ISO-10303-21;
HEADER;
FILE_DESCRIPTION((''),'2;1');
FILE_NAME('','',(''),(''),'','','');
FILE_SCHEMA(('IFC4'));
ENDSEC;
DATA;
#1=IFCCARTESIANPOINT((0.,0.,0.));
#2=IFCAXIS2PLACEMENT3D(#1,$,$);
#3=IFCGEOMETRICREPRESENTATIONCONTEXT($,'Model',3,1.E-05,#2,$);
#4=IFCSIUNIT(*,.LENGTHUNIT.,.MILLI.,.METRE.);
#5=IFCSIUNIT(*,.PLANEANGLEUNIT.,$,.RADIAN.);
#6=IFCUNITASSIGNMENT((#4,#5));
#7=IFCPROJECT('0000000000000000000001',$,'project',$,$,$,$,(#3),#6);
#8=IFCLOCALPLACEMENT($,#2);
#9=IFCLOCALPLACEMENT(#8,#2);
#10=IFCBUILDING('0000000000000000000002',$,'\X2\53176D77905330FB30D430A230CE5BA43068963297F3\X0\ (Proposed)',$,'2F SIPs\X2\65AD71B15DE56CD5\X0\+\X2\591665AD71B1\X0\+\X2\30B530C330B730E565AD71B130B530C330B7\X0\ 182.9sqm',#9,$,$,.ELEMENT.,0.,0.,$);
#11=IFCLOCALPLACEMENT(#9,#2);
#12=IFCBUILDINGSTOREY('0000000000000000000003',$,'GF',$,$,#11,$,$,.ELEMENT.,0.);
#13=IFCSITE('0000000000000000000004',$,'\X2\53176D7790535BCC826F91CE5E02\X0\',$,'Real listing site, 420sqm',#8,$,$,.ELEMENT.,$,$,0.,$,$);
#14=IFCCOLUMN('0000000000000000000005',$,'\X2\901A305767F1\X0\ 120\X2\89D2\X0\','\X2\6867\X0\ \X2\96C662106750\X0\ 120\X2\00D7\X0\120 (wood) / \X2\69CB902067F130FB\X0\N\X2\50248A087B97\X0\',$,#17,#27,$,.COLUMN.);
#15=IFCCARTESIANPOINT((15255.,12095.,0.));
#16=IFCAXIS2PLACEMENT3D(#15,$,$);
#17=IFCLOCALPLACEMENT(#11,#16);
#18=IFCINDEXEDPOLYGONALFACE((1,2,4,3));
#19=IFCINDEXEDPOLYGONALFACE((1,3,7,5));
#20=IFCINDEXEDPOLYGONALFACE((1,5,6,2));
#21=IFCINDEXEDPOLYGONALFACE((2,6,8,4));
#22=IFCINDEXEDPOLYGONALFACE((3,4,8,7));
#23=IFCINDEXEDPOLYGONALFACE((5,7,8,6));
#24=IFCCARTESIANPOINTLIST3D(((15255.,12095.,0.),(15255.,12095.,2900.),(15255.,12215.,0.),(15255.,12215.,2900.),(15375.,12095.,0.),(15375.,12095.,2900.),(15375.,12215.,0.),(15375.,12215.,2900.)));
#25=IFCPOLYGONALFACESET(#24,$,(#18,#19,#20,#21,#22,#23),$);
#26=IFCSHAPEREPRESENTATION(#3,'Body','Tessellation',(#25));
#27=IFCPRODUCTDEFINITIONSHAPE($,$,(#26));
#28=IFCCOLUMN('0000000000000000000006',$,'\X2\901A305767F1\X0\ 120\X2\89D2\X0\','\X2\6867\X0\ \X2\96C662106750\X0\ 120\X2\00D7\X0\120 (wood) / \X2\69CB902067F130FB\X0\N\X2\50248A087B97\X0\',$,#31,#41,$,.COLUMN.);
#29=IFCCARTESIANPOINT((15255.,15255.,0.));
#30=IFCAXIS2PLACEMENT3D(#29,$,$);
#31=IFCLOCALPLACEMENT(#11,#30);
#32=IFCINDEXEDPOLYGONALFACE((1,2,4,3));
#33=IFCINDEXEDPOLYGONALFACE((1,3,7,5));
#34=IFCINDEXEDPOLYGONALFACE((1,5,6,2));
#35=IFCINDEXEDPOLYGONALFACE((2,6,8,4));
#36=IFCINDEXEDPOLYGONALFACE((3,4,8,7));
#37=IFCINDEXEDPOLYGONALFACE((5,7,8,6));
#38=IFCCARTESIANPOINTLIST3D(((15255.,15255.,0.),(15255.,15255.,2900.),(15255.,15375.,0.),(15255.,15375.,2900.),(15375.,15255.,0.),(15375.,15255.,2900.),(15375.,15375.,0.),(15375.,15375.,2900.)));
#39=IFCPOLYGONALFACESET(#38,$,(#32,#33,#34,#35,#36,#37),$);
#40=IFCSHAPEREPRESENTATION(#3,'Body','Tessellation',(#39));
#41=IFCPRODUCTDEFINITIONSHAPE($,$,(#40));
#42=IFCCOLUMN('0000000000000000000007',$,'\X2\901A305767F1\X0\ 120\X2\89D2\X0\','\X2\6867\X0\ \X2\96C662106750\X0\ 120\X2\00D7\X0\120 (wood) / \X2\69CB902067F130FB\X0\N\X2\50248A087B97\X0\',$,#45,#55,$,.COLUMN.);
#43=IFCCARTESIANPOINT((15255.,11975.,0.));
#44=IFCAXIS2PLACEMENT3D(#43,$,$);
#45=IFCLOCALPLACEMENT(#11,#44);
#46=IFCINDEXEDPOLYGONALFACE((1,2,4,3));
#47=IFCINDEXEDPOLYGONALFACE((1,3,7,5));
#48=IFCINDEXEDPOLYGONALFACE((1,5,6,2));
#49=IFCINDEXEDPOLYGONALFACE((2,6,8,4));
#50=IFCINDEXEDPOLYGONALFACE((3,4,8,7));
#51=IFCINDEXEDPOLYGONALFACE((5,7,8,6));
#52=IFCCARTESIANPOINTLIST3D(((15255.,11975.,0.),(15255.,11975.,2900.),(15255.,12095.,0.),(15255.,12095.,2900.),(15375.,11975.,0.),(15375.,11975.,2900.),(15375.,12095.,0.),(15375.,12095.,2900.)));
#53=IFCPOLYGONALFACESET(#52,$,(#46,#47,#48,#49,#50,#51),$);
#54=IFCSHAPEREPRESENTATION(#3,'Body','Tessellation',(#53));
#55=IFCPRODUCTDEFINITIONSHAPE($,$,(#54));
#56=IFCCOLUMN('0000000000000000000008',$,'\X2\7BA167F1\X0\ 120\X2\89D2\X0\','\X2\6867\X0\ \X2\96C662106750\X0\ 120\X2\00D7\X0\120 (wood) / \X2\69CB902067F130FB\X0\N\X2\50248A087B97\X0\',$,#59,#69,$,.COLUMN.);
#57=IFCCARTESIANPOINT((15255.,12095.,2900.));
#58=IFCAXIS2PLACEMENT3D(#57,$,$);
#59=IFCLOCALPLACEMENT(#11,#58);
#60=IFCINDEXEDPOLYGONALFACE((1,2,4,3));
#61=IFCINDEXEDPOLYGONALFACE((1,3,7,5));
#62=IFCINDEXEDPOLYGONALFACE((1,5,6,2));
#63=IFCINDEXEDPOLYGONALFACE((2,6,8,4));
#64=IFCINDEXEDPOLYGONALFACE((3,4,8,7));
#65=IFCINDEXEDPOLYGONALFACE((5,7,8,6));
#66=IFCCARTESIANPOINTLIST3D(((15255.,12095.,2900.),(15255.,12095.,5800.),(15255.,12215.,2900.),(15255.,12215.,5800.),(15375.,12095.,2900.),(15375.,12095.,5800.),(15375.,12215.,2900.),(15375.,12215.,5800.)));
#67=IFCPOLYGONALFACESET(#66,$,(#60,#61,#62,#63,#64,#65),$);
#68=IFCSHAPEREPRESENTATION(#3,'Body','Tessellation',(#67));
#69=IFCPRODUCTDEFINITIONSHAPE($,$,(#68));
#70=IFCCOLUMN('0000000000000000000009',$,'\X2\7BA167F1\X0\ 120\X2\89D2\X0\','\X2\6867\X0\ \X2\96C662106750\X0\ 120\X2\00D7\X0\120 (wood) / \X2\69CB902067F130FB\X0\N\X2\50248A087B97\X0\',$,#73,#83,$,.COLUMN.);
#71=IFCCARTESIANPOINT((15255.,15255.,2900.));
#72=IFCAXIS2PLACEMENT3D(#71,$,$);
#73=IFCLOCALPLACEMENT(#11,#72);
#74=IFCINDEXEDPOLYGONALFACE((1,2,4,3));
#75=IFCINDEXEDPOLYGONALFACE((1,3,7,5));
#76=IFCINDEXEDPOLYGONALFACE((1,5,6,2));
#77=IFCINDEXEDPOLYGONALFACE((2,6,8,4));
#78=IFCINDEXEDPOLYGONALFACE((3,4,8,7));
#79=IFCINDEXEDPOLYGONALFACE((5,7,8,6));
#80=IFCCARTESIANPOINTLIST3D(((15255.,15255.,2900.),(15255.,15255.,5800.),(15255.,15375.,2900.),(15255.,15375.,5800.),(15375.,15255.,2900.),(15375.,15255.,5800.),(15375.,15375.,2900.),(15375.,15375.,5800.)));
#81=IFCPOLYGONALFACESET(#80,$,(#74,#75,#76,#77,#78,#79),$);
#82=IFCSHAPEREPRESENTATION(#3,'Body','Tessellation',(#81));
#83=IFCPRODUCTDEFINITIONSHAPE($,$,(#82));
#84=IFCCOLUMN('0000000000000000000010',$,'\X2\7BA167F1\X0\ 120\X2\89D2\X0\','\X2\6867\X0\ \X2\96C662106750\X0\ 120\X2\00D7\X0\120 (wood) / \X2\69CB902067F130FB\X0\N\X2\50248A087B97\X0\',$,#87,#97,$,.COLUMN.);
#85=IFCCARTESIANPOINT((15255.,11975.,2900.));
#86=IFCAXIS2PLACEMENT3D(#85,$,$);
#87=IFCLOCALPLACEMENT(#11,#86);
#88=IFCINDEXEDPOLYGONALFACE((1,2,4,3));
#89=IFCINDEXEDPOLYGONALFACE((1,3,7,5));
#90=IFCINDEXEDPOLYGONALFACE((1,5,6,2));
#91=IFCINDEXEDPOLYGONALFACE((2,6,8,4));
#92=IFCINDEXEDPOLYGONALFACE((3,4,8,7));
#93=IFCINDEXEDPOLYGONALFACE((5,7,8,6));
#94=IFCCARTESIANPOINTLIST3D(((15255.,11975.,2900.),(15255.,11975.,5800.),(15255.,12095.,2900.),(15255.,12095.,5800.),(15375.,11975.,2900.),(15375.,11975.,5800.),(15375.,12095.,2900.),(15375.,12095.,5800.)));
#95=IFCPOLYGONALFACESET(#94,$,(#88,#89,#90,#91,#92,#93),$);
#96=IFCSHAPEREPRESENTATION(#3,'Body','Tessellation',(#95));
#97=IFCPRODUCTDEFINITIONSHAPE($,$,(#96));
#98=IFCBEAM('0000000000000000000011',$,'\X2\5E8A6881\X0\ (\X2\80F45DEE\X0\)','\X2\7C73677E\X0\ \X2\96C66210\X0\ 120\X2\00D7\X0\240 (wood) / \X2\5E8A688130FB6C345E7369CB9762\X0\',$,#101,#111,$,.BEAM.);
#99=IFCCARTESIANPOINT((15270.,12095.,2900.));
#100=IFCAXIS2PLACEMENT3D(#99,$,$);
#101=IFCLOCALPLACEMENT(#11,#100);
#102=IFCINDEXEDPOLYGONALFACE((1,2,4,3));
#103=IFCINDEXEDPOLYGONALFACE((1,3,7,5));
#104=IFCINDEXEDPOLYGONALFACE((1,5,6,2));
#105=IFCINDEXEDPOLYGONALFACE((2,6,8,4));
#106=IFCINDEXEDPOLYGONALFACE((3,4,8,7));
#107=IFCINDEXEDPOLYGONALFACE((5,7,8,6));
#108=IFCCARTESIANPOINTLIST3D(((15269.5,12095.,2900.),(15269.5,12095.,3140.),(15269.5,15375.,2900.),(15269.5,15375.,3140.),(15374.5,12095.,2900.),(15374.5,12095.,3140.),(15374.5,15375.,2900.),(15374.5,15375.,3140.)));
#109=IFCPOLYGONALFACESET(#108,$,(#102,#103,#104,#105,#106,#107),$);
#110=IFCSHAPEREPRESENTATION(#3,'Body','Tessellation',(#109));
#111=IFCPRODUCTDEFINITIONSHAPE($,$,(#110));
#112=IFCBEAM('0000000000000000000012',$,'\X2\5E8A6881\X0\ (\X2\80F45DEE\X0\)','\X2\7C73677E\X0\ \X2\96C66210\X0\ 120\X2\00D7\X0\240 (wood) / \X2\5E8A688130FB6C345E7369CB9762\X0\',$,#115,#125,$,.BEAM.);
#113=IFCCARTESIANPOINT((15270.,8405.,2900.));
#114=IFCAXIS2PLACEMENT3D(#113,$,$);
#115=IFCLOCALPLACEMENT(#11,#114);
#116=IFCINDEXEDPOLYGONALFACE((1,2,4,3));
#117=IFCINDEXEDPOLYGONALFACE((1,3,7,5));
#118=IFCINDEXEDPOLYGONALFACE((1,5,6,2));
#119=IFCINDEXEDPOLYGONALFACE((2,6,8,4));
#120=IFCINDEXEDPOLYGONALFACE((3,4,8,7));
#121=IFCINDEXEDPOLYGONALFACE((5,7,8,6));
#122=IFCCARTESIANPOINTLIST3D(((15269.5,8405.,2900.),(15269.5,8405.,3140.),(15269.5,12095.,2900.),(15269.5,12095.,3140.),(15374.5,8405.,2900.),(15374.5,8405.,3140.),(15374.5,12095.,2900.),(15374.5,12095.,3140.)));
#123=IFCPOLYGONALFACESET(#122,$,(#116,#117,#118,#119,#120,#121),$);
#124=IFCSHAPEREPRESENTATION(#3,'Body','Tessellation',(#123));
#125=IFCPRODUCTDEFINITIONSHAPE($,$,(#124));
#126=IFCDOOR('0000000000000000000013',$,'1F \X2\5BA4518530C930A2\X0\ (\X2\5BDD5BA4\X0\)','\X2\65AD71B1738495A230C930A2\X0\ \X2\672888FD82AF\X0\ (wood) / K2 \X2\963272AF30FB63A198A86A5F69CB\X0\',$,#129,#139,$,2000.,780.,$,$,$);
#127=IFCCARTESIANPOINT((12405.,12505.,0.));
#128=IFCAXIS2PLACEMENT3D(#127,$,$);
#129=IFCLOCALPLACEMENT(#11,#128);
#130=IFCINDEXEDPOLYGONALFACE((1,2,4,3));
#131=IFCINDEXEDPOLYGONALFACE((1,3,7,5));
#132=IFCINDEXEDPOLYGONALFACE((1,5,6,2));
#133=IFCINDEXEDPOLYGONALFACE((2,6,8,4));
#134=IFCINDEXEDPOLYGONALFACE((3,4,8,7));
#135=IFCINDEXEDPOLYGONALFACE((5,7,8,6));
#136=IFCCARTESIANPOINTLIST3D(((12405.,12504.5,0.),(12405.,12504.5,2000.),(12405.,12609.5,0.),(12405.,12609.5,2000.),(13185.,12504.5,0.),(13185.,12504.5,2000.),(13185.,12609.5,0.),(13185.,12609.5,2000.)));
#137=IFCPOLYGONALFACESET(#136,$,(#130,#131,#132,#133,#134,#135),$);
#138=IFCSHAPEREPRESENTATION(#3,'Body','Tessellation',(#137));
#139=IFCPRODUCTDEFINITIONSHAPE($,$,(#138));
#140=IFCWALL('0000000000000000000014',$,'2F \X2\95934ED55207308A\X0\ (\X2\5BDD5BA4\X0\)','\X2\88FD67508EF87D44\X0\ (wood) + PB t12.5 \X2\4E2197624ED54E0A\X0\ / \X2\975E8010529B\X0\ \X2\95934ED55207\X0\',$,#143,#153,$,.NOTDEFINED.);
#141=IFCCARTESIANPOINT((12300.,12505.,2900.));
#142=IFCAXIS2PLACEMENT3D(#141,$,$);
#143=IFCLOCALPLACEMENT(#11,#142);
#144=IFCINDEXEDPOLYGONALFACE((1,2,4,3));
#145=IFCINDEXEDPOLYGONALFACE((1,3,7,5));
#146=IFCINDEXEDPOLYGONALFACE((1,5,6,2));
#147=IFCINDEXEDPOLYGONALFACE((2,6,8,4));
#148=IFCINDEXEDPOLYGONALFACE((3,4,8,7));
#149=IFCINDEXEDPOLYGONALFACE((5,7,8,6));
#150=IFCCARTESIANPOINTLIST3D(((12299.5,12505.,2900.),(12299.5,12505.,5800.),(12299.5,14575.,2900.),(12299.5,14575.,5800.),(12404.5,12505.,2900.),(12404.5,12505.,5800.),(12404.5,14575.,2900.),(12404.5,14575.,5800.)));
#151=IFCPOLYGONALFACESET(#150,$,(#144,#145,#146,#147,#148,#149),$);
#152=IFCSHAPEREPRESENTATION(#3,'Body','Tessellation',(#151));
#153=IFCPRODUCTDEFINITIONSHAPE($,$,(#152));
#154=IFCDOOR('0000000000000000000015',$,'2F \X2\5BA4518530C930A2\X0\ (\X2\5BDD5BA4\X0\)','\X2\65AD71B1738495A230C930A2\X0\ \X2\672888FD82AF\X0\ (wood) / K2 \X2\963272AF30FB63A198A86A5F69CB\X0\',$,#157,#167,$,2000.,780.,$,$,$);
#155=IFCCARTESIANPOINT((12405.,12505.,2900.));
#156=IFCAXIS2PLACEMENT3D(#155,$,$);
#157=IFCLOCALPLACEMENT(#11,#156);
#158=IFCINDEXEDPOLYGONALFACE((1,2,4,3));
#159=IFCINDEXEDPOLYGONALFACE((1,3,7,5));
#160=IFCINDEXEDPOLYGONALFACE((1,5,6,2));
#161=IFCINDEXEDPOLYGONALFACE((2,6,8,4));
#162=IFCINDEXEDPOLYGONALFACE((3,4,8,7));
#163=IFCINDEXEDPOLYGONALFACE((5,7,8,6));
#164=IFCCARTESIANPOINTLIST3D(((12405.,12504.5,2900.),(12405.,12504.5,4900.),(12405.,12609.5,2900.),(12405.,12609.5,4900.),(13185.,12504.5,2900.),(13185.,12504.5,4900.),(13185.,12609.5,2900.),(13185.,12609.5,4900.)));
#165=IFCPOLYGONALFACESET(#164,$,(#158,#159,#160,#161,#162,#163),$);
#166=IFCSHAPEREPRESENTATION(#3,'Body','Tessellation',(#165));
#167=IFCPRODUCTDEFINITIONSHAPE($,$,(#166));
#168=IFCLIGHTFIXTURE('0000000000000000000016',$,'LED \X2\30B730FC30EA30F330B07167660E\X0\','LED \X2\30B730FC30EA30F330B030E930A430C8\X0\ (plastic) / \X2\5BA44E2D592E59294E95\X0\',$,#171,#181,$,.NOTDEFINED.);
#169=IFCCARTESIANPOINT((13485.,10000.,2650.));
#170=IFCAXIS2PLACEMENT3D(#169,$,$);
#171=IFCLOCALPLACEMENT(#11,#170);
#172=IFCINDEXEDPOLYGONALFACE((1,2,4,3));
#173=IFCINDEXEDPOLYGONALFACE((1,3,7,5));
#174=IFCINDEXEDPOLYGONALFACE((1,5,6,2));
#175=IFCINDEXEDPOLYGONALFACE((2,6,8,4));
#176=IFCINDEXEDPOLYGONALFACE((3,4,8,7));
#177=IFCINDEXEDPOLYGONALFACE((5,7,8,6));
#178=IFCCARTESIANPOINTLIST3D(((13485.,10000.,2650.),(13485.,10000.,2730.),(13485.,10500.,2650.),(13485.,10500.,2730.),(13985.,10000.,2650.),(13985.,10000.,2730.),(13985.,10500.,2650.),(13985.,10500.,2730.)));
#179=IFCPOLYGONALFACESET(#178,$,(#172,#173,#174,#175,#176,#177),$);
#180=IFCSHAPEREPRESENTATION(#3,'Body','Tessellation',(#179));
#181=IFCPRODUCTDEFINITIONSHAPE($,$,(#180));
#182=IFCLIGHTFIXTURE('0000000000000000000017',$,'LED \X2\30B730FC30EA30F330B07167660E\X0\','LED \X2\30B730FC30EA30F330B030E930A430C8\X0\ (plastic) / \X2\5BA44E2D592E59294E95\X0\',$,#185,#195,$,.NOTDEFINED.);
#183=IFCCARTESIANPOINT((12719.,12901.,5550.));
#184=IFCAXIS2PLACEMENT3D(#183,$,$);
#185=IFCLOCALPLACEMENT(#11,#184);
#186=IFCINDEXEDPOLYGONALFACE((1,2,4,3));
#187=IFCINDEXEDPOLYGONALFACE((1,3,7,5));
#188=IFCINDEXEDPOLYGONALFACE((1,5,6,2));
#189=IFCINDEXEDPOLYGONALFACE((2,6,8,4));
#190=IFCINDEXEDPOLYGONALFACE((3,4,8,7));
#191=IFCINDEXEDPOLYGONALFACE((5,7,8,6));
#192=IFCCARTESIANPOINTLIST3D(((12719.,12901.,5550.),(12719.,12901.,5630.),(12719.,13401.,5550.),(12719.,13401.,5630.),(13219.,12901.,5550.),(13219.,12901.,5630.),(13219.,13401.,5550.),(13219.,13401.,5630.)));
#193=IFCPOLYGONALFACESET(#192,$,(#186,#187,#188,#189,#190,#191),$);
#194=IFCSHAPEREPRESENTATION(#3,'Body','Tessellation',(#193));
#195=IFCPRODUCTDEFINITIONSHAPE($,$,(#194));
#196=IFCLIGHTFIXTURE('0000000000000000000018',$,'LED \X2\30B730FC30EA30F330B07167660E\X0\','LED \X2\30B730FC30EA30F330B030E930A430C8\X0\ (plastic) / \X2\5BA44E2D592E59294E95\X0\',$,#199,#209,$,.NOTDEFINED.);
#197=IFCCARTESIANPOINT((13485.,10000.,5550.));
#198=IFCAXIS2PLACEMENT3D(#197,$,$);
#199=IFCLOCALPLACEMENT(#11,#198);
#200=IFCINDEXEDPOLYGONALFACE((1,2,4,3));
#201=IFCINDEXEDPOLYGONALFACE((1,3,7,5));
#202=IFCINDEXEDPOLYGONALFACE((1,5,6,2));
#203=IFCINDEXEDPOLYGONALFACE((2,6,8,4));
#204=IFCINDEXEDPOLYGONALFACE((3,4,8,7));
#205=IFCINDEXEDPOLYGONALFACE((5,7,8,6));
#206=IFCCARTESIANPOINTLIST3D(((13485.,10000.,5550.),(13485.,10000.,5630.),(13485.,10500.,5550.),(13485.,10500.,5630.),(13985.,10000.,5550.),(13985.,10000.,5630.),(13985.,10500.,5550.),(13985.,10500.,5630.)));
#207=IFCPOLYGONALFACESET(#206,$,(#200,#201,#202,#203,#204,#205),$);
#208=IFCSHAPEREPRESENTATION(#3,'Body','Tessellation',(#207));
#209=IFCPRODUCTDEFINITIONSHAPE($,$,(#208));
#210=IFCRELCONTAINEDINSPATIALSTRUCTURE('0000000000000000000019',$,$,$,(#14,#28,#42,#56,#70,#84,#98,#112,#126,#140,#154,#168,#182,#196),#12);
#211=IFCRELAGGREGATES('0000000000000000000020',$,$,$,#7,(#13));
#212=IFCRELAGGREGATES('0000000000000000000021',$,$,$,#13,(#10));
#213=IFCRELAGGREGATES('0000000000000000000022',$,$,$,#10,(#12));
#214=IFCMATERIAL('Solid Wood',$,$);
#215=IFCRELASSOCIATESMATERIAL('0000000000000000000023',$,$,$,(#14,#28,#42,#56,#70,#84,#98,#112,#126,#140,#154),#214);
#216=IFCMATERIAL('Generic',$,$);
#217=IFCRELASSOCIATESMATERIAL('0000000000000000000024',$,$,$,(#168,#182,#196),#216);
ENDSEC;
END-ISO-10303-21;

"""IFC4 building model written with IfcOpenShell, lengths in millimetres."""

from ifc_helpers import new_model, si_unit, frame, frame_2d, origin, place, context, project, spatial, rectangle, extrude, material, element, save


model = new_model("IFC4")

# Units and contexts
model_context = context("Model", 3, precision=1e-05, world=origin())
ifc_project = project(units=[si_unit("LENGTHUNIT", "METRE", prefix="MILLI"), si_unit("PLANEANGLEUNIT", "RADIAN")], contexts=[model_context])

# Site, building, storey
site_placement = place(None, origin())
site = spatial("IfcSite", under=ifc_project, at=site_placement, Name="北海道富良野市", ObjectType="Real listing site, 420sqm", CompositionType="ELEMENT", RefElevation=0.0)
building_placement = place(site_placement, origin())
building = spatial("IfcBuilding", under=site, at=building_placement, Name="北海道・ピアノ室と防音 (Proposed)", ObjectType="2F SIPs断熱工法+外断熱+サッシュ断熱サッシ 182.9sqm", CompositionType="ELEMENT", ElevationOfRefHeight=0.0, ElevationOfTerrain=0.0)
storey_placement = place(building_placement, origin())
storey = spatial("IfcBuildingStorey", under=building, at=storey_placement, Name="GF", CompositionType="ELEMENT", Elevation=0.0)

# Columns
ifc_material_1 = material(Name="Solid Wood")
column_1_placement = place(storey_placement, frame((15255.0, 12095.0, 0.0)))
element("IfcColumn", 1, at=column_1_placement, inside=storey, material=ifc_material_1, Name="通し柱 120角", Description="桧 集成材 120×120 (wood) / 構造柱・N値計算", PredefinedType="COLUMN", context=model_context, shape_type="SweptSolid", body=[
    extrude(rectangle(XDim=120.0, YDim=120.0, at=frame_2d((60.0, 60.0))), frame((15255.0, 12095.0, 0.0)), (0.0, 0.0, 1.0), 2900.0),
])
column_2_placement = place(storey_placement, frame((15255.0, 15255.0, 0.0)))
element("IfcColumn", 2, at=column_2_placement, inside=storey, material=ifc_material_1, Name="通し柱 120角", Description="桧 集成材 120×120 (wood) / 構造柱・N値計算", PredefinedType="COLUMN", context=model_context, shape_type="SweptSolid", body=[
    extrude(rectangle(XDim=120.0, YDim=120.0, at=frame_2d((60.0, 60.0))), frame((15255.0, 15255.0, 0.0)), (0.0, 0.0, 1.0), 2900.0),
])
column_3_placement = place(storey_placement, frame((15255.0, 11975.0, 0.0)))
element("IfcColumn", 3, at=column_3_placement, inside=storey, material=ifc_material_1, Name="通し柱 120角", Description="桧 集成材 120×120 (wood) / 構造柱・N値計算", PredefinedType="COLUMN", context=model_context, shape_type="SweptSolid", body=[
    extrude(rectangle(XDim=120.0, YDim=120.0, at=frame_2d((60.0, 60.0))), frame((15255.0, 11975.0, 0.0)), (0.0, 0.0, 1.0), 2900.0),
])
column_4_placement = place(storey_placement, frame((15255.0, 12095.0, 2900.0)))
element("IfcColumn", 4, at=column_4_placement, inside=storey, material=ifc_material_1, Name="管柱 120角", Description="桧 集成材 120×120 (wood) / 構造柱・N値計算", PredefinedType="COLUMN", context=model_context, shape_type="SweptSolid", body=[
    extrude(rectangle(XDim=120.0, YDim=120.0, at=frame_2d((60.0, 60.0))), frame((15255.0, 12095.0, 2900.0)), (0.0, 0.0, 1.0), 2900.0),
])
column_5_placement = place(storey_placement, frame((15255.0, 15255.0, 2900.0)))
element("IfcColumn", 5, at=column_5_placement, inside=storey, material=ifc_material_1, Name="管柱 120角", Description="桧 集成材 120×120 (wood) / 構造柱・N値計算", PredefinedType="COLUMN", context=model_context, shape_type="SweptSolid", body=[
    extrude(rectangle(XDim=120.0, YDim=120.0, at=frame_2d((60.0, 60.0))), frame((15255.0, 15255.0, 2900.0)), (0.0, 0.0, 1.0), 2900.0),
])
column_6_placement = place(storey_placement, frame((15255.0, 11975.0, 2900.0)))
element("IfcColumn", 6, at=column_6_placement, inside=storey, material=ifc_material_1, Name="管柱 120角", Description="桧 集成材 120×120 (wood) / 構造柱・N値計算", PredefinedType="COLUMN", context=model_context, shape_type="SweptSolid", body=[
    extrude(rectangle(XDim=120.0, YDim=120.0, at=frame_2d((60.0, 60.0))), frame((15255.0, 11975.0, 2900.0)), (0.0, 0.0, 1.0), 2900.0),
])

# Beams
beam_1_placement = place(storey_placement, frame((15270.0, 12095.0, 2900.0)))
element("IfcBeam", 7, at=beam_1_placement, inside=storey, material=ifc_material_1, Name="床梁 (胴差)", Description="米松 集成 120×240 (wood) / 床梁・水平構面", PredefinedType="BEAM", context=model_context, shape_type="SweptSolid", body=[
    extrude(rectangle(XDim=105.0, YDim=3280.0, at=frame_2d((52.0, 1640.0))), frame((15270.0, 12095.0, 2900.0)), (0.0, 0.0, 1.0), 240.0),
])
beam_2_placement = place(storey_placement, frame((15270.0, 8405.0, 2900.0)))
element("IfcBeam", 8, at=beam_2_placement, inside=storey, material=ifc_material_1, Name="床梁 (胴差)", Description="米松 集成 120×240 (wood) / 床梁・水平構面", PredefinedType="BEAM", context=model_context, shape_type="SweptSolid", body=[
    extrude(rectangle(XDim=105.0, YDim=3690.0, at=frame_2d((52.0, 1845.0))), frame((15270.0, 8405.0, 2900.0)), (0.0, 0.0, 1.0), 240.0),
])

# Door
door_1_placement = place(storey_placement, frame((12405.0, 12505.0, 0.0)))
element("IfcDoor", 9, at=door_1_placement, inside=storey, material=ifc_material_1, Name="1F 室内ドア (寝室)", Description="断熱玄関ドア 木製芯 (wood) / K2 防犯・採風機構", OverallHeight=2000.0, OverallWidth=780.0, context=model_context, shape_type="SweptSolid", body=[
    extrude(rectangle(XDim=780.0, YDim=105.0, at=frame_2d((390.0, 52.0))), frame((12405.0, 12505.0, 0.0)), (0.0, 0.0, 1.0), 2000.0),
])

# Wall
wall_placement = place(storey_placement, frame((12300.0, 12505.0, 2900.0)))
element("IfcWall", 10, at=wall_placement, inside=storey, material=ifc_material_1, Name="2F 間仕切り (寝室)", Description="製材軸組 (wood) + PB t12.5 両面仕上 / 非耐力 間仕切", PredefinedType="NOTDEFINED", context=model_context, shape_type="SweptSolid", body=[
    extrude(rectangle(XDim=105.0, YDim=2070.0, at=frame_2d((52.0, 1035.0))), frame((12300.0, 12505.0, 2900.0)), (0.0, 0.0, 1.0), 2900.0),
])

# Door
door_2_placement = place(storey_placement, frame((12405.0, 12505.0, 2900.0)))
element("IfcDoor", 11, at=door_2_placement, inside=storey, material=ifc_material_1, Name="2F 室内ドア (寝室)", Description="断熱玄関ドア 木製芯 (wood) / K2 防犯・採風機構", OverallHeight=2000.0, OverallWidth=780.0, context=model_context, shape_type="SweptSolid", body=[
    extrude(rectangle(XDim=780.0, YDim=105.0, at=frame_2d((390.0, 52.0))), frame((12405.0, 12505.0, 2900.0)), (0.0, 0.0, 1.0), 2000.0),
])

# Light fixtures
ifc_material_2 = material(Name="Generic")
light_fixture_1_placement = place(storey_placement, frame((13485.0, 10000.0, 2650.0)))
element("IfcLightFixture", 12, at=light_fixture_1_placement, inside=storey, material=ifc_material_2, Name="LED シーリング照明", Description="LED シーリングライト (plastic) / 室中央天井", PredefinedType="NOTDEFINED", context=model_context, shape_type="SweptSolid", body=[
    extrude(rectangle(XDim=500.0, YDim=500.0, at=frame_2d((250.0, 250.0))), frame((13485.0, 10000.0, 2650.0)), (0.0, 0.0, 1.0), 80.0),
])
light_fixture_2_placement = place(storey_placement, frame((12719.0, 12901.0, 5550.0)))
element("IfcLightFixture", 13, at=light_fixture_2_placement, inside=storey, material=ifc_material_2, Name="LED シーリング照明", Description="LED シーリングライト (plastic) / 室中央天井", PredefinedType="NOTDEFINED", context=model_context, shape_type="SweptSolid", body=[
    extrude(rectangle(XDim=500.0, YDim=500.0, at=frame_2d((250.0, 250.0))), frame((12719.0, 12901.0, 5550.0)), (0.0, 0.0, 1.0), 80.0),
])
light_fixture_3_placement = place(storey_placement, frame((13485.0, 10000.0, 5550.0)))
element("IfcLightFixture", 14, at=light_fixture_3_placement, inside=storey, material=ifc_material_2, Name="LED シーリング照明", Description="LED シーリングライト (plastic) / 室中央天井", PredefinedType="NOTDEFINED", context=model_context, shape_type="SweptSolid", body=[
    extrude(rectangle(XDim=500.0, YDim=500.0, at=frame_2d((250.0, 250.0))), frame((13485.0, 10000.0, 5550.0)), (0.0, 0.0, 1.0), 80.0),
])

save(model, "model.ifc")
